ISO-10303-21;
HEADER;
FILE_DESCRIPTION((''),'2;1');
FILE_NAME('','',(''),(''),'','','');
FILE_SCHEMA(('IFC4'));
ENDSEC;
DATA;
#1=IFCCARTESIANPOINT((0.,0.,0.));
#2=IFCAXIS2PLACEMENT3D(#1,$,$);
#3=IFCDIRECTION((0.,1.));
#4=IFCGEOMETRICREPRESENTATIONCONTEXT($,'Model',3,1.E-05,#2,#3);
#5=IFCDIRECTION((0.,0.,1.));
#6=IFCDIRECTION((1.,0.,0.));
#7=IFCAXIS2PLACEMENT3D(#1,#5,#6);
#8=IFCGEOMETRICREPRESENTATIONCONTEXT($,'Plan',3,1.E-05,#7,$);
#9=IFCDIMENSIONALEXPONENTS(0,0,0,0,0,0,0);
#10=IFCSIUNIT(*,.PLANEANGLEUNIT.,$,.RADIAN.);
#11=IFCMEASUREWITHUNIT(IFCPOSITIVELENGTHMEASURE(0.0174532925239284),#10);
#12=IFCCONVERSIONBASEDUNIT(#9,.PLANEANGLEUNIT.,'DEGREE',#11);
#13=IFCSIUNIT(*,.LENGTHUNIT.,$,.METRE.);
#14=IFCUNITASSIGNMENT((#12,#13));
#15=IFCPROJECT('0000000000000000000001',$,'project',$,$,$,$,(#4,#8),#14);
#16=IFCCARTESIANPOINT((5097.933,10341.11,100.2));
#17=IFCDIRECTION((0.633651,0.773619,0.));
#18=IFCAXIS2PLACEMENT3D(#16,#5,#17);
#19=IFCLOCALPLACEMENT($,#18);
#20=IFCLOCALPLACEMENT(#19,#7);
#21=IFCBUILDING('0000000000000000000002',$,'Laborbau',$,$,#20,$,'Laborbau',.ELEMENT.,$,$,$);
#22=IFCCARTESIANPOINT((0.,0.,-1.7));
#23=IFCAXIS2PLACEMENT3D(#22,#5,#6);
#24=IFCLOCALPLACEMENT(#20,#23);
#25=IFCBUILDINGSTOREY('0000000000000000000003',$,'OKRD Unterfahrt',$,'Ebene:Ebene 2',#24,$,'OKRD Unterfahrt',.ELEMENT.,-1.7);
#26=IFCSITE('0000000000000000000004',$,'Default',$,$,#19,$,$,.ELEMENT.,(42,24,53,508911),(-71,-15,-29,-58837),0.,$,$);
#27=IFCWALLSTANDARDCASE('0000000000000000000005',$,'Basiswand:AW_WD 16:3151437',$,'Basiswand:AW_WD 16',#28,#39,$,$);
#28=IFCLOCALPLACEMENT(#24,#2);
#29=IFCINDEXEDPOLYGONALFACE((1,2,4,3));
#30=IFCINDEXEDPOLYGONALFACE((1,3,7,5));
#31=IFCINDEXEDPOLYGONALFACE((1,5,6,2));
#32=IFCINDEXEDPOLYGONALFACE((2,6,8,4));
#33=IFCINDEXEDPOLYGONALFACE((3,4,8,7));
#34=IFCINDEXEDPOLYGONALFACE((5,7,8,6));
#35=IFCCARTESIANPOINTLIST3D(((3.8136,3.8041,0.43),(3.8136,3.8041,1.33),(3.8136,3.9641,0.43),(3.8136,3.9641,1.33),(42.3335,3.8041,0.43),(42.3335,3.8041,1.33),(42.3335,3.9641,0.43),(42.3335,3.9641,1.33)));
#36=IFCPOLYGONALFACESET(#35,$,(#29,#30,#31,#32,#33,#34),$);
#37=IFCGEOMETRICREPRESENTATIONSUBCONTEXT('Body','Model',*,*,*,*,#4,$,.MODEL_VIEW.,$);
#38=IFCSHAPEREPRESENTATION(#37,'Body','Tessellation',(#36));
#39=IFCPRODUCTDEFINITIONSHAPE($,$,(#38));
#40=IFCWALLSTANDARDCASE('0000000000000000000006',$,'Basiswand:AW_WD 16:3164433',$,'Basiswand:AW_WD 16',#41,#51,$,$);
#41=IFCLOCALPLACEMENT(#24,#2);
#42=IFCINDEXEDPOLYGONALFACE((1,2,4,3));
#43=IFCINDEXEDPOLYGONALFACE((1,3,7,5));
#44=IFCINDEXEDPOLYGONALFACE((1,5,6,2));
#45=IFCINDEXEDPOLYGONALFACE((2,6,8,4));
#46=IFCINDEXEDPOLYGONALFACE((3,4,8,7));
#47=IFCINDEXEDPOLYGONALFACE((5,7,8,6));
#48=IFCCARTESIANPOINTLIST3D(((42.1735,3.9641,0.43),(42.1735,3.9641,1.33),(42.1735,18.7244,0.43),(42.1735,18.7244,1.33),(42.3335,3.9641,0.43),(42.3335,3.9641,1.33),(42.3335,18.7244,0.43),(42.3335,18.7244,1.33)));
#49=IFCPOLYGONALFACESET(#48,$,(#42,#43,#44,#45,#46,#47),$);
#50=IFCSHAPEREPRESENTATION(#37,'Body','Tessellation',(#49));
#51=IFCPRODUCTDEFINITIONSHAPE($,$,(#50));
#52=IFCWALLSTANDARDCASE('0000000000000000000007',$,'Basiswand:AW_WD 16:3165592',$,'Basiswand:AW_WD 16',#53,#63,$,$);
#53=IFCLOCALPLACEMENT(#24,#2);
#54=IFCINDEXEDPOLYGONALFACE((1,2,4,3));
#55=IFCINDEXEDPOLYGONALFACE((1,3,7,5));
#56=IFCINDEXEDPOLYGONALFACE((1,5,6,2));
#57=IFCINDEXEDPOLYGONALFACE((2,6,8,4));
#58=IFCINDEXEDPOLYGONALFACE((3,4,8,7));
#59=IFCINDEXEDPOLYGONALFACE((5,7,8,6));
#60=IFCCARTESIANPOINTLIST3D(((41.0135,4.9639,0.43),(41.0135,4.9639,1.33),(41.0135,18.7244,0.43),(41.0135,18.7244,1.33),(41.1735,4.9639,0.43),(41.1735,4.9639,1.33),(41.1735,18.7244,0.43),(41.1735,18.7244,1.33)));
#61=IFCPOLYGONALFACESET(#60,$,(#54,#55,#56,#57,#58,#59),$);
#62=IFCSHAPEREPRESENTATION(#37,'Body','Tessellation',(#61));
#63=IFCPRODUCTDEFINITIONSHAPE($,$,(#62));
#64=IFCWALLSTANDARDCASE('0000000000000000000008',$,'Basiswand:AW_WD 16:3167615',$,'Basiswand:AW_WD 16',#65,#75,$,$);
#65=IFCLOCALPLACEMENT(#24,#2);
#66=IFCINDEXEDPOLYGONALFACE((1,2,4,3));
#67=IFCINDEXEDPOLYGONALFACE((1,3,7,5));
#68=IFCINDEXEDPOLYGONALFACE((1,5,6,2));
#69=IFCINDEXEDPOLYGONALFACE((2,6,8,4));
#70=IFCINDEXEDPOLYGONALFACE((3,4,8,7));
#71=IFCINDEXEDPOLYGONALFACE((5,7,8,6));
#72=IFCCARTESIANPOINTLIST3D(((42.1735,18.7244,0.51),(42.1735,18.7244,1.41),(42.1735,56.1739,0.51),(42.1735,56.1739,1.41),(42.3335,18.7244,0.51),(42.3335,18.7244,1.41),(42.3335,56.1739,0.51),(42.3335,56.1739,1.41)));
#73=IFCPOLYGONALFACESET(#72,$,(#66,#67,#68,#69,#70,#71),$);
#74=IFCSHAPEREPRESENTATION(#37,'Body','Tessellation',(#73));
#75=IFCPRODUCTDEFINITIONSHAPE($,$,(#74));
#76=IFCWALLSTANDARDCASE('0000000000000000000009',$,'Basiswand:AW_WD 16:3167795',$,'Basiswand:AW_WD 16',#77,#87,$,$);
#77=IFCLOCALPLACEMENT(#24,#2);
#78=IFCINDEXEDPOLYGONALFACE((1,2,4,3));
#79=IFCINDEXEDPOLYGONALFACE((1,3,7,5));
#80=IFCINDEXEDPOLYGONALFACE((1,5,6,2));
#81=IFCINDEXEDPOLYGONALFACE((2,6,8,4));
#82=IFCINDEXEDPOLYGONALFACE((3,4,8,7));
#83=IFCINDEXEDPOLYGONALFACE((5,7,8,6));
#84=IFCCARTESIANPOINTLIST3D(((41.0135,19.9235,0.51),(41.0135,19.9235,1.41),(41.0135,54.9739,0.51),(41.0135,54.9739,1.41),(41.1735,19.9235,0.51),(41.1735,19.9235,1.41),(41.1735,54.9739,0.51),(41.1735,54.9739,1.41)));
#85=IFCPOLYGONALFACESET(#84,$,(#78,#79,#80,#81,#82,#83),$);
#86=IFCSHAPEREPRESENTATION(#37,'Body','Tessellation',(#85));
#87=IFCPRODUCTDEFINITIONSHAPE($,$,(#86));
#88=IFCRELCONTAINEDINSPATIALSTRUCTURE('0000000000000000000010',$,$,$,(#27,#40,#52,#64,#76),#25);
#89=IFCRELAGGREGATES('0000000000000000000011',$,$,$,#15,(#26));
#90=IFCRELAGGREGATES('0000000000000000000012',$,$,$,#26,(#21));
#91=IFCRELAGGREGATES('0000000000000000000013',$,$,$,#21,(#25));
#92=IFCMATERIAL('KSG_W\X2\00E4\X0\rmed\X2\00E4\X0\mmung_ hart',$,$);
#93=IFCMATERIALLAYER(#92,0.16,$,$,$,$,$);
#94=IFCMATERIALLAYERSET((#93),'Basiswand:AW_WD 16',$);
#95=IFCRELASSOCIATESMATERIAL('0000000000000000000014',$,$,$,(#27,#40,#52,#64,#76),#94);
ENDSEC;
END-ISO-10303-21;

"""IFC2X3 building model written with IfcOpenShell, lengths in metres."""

from ifc_helpers import new_model, entity, si_unit, converted_unit, direction, frame, frame_2d, origin, origin_with_axes, place, context, subcontext, project, spatial, rectangle, extrude, material, layer, layer_set, layer_usage, element, save


model = new_model("IFC2X3")

# Units and contexts
model_context = context("Model", 3, precision=1e-05, world=origin(), true_north=direction((0.0, 1.0)))
plan_context = context("Plan", 3, precision=1e-05, world=origin_with_axes())
body_context = subcontext(model_context, "Body", "Model", "MODEL_VIEW")
ifc_project = project(units=[converted_unit("PLANEANGLEUNIT", "DEGREE", entity("IfcPositiveLengthMeasure", 0.0174532925239284), si_unit("PLANEANGLEUNIT", "RADIAN"), dimensions=[0, 0, 0, 0, 0, 0, 0]), si_unit("LENGTHUNIT", "METRE")], contexts=[model_context, plan_context])

# Site, building, storey
site_placement = place(None, frame((5097.933, 10341.11, 100.2), z_axis=(0.0, 0.0, 1.0), x_axis=(0.633651, 0.773619, 0.0)))
site = spatial("IfcSite", under=ifc_project, at=site_placement, Name="Default", CompositionType="ELEMENT", RefLatitude=(42, 24, 53, 508911), RefLongitude=(-71, -15, -29, -58837), RefElevation=0.0)
building_placement = place(site_placement, origin_with_axes())
building = spatial("IfcBuilding", under=site, at=building_placement, Name="Laborbau", LongName="Laborbau", CompositionType="ELEMENT")
storey_placement = place(building_placement, frame((0.0, 0.0, -1.7), z_axis=(0.0, 0.0, 1.0), x_axis=(1.0, 0.0, 0.0)))
storey = spatial("IfcBuildingStorey", under=building, at=storey_placement, Name="OKRD Unterfahrt", ObjectType="Ebene:Ebene 2", LongName="OKRD Unterfahrt", CompositionType="ELEMENT", Elevation=-1.7)

# Walls
ifc_material_1 = material(Name="KSG_Wärmedämmung_ hart")
ifc_layer = layer(ifc_material_1, 0.16)
ifc_layer_set = layer_set([ifc_layer], Name="Basiswand:AW_WD 16")
ifc_layer_usage_1 = layer_usage(ifc_layer_set, "AXIS2", "NEGATIVE", 0.08)
wall_1_placement = place(storey_placement, frame((42.3335, 3.8841, 0.43), z_axis=(0.0, 0.0, 1.0), x_axis=(-1.0, 0.0, 0.0)))
element("IfcWallStandardCase", 1, at=wall_1_placement, inside=storey, material=ifc_layer_usage_1, Name="Basiswand:AW_WD 16:3151437", ObjectType="Basiswand:AW_WD 16", context=body_context, shape_type="SweptSolid", body=[
    extrude(rectangle(XDim=38.5199, YDim=0.16, at=frame_2d((19.26, 0.0), x_axis=(-1.0, 0.0))), origin(), (0.0, 0.0, 1.0), 0.9),
])
ifc_layer_usage_2 = layer_usage(ifc_layer_set, "AXIS2", "NEGATIVE", 0.08)
wall_2_placement = place(storey_placement, frame((42.2535, 3.9641, 0.43), z_axis=(0.0, 0.0, 1.0), x_axis=(0.0, 1.0, 0.0)))
element("IfcWallStandardCase", 2, at=wall_2_placement, inside=storey, material=ifc_layer_usage_2, Name="Basiswand:AW_WD 16:3164433", ObjectType="Basiswand:AW_WD 16", context=body_context, shape_type="SweptSolid", body=[
    extrude(rectangle(XDim=14.7603, YDim=0.16, at=frame_2d((7.3801, 0.0), x_axis=(-1.0, 0.0))), origin(), (0.0, 0.0, 1.0), 0.9),
])
ifc_layer_usage_3 = layer_usage(ifc_layer_set, "AXIS2", "NEGATIVE", 0.08)
wall_3_placement = place(storey_placement, frame((41.0935, 4.9639, 0.43), z_axis=(0.0, 0.0, 1.0), x_axis=(0.0, 1.0, 0.0)))
element("IfcWallStandardCase", 3, at=wall_3_placement, inside=storey, material=ifc_layer_usage_3, Name="Basiswand:AW_WD 16:3165592", ObjectType="Basiswand:AW_WD 16", context=body_context, shape_type="SweptSolid", body=[
    extrude(rectangle(XDim=13.7605, YDim=0.16, at=frame_2d((6.8803, 0.0), x_axis=(-1.0, 0.0))), origin(), (0.0, 0.0, 1.0), 0.9),
])
ifc_layer_usage_4 = layer_usage(ifc_layer_set, "AXIS2", "NEGATIVE", 0.08)
wall_4_placement = place(storey_placement, frame((42.2535, 18.7244, 0.51), z_axis=(0.0, 0.0, 1.0), x_axis=(0.0, 1.0, 0.0)))
element("IfcWallStandardCase", 4, at=wall_4_placement, inside=storey, material=ifc_layer_usage_4, Name="Basiswand:AW_WD 16:3167615", ObjectType="Basiswand:AW_WD 16", context=body_context, shape_type="SweptSolid", body=[
    extrude(rectangle(XDim=37.4495, YDim=0.16, at=frame_2d((18.7247, 0.0), x_axis=(-1.0, 0.0))), origin(), (0.0, 0.0, 1.0), 0.9),
])
ifc_layer_usage_5 = layer_usage(ifc_layer_set, "AXIS2", "NEGATIVE", 0.08)
wall_5_placement = place(storey_placement, frame((41.0935, 19.9235, 0.51), z_axis=(0.0, 0.0, 1.0), x_axis=(0.0, 1.0, 0.0)))
element("IfcWallStandardCase", 5, at=wall_5_placement, inside=storey, material=ifc_layer_usage_5, Name="Basiswand:AW_WD 16:3167795", ObjectType="Basiswand:AW_WD 16", context=body_context, shape_type="SweptSolid", body=[
    extrude(rectangle(XDim=35.0503, YDim=0.16, at=frame_2d((17.5252, 0.0), x_axis=(-1.0, 0.0))), origin(), (0.0, 0.0, 1.0), 0.9),
])

save(model, "model.ifc")
